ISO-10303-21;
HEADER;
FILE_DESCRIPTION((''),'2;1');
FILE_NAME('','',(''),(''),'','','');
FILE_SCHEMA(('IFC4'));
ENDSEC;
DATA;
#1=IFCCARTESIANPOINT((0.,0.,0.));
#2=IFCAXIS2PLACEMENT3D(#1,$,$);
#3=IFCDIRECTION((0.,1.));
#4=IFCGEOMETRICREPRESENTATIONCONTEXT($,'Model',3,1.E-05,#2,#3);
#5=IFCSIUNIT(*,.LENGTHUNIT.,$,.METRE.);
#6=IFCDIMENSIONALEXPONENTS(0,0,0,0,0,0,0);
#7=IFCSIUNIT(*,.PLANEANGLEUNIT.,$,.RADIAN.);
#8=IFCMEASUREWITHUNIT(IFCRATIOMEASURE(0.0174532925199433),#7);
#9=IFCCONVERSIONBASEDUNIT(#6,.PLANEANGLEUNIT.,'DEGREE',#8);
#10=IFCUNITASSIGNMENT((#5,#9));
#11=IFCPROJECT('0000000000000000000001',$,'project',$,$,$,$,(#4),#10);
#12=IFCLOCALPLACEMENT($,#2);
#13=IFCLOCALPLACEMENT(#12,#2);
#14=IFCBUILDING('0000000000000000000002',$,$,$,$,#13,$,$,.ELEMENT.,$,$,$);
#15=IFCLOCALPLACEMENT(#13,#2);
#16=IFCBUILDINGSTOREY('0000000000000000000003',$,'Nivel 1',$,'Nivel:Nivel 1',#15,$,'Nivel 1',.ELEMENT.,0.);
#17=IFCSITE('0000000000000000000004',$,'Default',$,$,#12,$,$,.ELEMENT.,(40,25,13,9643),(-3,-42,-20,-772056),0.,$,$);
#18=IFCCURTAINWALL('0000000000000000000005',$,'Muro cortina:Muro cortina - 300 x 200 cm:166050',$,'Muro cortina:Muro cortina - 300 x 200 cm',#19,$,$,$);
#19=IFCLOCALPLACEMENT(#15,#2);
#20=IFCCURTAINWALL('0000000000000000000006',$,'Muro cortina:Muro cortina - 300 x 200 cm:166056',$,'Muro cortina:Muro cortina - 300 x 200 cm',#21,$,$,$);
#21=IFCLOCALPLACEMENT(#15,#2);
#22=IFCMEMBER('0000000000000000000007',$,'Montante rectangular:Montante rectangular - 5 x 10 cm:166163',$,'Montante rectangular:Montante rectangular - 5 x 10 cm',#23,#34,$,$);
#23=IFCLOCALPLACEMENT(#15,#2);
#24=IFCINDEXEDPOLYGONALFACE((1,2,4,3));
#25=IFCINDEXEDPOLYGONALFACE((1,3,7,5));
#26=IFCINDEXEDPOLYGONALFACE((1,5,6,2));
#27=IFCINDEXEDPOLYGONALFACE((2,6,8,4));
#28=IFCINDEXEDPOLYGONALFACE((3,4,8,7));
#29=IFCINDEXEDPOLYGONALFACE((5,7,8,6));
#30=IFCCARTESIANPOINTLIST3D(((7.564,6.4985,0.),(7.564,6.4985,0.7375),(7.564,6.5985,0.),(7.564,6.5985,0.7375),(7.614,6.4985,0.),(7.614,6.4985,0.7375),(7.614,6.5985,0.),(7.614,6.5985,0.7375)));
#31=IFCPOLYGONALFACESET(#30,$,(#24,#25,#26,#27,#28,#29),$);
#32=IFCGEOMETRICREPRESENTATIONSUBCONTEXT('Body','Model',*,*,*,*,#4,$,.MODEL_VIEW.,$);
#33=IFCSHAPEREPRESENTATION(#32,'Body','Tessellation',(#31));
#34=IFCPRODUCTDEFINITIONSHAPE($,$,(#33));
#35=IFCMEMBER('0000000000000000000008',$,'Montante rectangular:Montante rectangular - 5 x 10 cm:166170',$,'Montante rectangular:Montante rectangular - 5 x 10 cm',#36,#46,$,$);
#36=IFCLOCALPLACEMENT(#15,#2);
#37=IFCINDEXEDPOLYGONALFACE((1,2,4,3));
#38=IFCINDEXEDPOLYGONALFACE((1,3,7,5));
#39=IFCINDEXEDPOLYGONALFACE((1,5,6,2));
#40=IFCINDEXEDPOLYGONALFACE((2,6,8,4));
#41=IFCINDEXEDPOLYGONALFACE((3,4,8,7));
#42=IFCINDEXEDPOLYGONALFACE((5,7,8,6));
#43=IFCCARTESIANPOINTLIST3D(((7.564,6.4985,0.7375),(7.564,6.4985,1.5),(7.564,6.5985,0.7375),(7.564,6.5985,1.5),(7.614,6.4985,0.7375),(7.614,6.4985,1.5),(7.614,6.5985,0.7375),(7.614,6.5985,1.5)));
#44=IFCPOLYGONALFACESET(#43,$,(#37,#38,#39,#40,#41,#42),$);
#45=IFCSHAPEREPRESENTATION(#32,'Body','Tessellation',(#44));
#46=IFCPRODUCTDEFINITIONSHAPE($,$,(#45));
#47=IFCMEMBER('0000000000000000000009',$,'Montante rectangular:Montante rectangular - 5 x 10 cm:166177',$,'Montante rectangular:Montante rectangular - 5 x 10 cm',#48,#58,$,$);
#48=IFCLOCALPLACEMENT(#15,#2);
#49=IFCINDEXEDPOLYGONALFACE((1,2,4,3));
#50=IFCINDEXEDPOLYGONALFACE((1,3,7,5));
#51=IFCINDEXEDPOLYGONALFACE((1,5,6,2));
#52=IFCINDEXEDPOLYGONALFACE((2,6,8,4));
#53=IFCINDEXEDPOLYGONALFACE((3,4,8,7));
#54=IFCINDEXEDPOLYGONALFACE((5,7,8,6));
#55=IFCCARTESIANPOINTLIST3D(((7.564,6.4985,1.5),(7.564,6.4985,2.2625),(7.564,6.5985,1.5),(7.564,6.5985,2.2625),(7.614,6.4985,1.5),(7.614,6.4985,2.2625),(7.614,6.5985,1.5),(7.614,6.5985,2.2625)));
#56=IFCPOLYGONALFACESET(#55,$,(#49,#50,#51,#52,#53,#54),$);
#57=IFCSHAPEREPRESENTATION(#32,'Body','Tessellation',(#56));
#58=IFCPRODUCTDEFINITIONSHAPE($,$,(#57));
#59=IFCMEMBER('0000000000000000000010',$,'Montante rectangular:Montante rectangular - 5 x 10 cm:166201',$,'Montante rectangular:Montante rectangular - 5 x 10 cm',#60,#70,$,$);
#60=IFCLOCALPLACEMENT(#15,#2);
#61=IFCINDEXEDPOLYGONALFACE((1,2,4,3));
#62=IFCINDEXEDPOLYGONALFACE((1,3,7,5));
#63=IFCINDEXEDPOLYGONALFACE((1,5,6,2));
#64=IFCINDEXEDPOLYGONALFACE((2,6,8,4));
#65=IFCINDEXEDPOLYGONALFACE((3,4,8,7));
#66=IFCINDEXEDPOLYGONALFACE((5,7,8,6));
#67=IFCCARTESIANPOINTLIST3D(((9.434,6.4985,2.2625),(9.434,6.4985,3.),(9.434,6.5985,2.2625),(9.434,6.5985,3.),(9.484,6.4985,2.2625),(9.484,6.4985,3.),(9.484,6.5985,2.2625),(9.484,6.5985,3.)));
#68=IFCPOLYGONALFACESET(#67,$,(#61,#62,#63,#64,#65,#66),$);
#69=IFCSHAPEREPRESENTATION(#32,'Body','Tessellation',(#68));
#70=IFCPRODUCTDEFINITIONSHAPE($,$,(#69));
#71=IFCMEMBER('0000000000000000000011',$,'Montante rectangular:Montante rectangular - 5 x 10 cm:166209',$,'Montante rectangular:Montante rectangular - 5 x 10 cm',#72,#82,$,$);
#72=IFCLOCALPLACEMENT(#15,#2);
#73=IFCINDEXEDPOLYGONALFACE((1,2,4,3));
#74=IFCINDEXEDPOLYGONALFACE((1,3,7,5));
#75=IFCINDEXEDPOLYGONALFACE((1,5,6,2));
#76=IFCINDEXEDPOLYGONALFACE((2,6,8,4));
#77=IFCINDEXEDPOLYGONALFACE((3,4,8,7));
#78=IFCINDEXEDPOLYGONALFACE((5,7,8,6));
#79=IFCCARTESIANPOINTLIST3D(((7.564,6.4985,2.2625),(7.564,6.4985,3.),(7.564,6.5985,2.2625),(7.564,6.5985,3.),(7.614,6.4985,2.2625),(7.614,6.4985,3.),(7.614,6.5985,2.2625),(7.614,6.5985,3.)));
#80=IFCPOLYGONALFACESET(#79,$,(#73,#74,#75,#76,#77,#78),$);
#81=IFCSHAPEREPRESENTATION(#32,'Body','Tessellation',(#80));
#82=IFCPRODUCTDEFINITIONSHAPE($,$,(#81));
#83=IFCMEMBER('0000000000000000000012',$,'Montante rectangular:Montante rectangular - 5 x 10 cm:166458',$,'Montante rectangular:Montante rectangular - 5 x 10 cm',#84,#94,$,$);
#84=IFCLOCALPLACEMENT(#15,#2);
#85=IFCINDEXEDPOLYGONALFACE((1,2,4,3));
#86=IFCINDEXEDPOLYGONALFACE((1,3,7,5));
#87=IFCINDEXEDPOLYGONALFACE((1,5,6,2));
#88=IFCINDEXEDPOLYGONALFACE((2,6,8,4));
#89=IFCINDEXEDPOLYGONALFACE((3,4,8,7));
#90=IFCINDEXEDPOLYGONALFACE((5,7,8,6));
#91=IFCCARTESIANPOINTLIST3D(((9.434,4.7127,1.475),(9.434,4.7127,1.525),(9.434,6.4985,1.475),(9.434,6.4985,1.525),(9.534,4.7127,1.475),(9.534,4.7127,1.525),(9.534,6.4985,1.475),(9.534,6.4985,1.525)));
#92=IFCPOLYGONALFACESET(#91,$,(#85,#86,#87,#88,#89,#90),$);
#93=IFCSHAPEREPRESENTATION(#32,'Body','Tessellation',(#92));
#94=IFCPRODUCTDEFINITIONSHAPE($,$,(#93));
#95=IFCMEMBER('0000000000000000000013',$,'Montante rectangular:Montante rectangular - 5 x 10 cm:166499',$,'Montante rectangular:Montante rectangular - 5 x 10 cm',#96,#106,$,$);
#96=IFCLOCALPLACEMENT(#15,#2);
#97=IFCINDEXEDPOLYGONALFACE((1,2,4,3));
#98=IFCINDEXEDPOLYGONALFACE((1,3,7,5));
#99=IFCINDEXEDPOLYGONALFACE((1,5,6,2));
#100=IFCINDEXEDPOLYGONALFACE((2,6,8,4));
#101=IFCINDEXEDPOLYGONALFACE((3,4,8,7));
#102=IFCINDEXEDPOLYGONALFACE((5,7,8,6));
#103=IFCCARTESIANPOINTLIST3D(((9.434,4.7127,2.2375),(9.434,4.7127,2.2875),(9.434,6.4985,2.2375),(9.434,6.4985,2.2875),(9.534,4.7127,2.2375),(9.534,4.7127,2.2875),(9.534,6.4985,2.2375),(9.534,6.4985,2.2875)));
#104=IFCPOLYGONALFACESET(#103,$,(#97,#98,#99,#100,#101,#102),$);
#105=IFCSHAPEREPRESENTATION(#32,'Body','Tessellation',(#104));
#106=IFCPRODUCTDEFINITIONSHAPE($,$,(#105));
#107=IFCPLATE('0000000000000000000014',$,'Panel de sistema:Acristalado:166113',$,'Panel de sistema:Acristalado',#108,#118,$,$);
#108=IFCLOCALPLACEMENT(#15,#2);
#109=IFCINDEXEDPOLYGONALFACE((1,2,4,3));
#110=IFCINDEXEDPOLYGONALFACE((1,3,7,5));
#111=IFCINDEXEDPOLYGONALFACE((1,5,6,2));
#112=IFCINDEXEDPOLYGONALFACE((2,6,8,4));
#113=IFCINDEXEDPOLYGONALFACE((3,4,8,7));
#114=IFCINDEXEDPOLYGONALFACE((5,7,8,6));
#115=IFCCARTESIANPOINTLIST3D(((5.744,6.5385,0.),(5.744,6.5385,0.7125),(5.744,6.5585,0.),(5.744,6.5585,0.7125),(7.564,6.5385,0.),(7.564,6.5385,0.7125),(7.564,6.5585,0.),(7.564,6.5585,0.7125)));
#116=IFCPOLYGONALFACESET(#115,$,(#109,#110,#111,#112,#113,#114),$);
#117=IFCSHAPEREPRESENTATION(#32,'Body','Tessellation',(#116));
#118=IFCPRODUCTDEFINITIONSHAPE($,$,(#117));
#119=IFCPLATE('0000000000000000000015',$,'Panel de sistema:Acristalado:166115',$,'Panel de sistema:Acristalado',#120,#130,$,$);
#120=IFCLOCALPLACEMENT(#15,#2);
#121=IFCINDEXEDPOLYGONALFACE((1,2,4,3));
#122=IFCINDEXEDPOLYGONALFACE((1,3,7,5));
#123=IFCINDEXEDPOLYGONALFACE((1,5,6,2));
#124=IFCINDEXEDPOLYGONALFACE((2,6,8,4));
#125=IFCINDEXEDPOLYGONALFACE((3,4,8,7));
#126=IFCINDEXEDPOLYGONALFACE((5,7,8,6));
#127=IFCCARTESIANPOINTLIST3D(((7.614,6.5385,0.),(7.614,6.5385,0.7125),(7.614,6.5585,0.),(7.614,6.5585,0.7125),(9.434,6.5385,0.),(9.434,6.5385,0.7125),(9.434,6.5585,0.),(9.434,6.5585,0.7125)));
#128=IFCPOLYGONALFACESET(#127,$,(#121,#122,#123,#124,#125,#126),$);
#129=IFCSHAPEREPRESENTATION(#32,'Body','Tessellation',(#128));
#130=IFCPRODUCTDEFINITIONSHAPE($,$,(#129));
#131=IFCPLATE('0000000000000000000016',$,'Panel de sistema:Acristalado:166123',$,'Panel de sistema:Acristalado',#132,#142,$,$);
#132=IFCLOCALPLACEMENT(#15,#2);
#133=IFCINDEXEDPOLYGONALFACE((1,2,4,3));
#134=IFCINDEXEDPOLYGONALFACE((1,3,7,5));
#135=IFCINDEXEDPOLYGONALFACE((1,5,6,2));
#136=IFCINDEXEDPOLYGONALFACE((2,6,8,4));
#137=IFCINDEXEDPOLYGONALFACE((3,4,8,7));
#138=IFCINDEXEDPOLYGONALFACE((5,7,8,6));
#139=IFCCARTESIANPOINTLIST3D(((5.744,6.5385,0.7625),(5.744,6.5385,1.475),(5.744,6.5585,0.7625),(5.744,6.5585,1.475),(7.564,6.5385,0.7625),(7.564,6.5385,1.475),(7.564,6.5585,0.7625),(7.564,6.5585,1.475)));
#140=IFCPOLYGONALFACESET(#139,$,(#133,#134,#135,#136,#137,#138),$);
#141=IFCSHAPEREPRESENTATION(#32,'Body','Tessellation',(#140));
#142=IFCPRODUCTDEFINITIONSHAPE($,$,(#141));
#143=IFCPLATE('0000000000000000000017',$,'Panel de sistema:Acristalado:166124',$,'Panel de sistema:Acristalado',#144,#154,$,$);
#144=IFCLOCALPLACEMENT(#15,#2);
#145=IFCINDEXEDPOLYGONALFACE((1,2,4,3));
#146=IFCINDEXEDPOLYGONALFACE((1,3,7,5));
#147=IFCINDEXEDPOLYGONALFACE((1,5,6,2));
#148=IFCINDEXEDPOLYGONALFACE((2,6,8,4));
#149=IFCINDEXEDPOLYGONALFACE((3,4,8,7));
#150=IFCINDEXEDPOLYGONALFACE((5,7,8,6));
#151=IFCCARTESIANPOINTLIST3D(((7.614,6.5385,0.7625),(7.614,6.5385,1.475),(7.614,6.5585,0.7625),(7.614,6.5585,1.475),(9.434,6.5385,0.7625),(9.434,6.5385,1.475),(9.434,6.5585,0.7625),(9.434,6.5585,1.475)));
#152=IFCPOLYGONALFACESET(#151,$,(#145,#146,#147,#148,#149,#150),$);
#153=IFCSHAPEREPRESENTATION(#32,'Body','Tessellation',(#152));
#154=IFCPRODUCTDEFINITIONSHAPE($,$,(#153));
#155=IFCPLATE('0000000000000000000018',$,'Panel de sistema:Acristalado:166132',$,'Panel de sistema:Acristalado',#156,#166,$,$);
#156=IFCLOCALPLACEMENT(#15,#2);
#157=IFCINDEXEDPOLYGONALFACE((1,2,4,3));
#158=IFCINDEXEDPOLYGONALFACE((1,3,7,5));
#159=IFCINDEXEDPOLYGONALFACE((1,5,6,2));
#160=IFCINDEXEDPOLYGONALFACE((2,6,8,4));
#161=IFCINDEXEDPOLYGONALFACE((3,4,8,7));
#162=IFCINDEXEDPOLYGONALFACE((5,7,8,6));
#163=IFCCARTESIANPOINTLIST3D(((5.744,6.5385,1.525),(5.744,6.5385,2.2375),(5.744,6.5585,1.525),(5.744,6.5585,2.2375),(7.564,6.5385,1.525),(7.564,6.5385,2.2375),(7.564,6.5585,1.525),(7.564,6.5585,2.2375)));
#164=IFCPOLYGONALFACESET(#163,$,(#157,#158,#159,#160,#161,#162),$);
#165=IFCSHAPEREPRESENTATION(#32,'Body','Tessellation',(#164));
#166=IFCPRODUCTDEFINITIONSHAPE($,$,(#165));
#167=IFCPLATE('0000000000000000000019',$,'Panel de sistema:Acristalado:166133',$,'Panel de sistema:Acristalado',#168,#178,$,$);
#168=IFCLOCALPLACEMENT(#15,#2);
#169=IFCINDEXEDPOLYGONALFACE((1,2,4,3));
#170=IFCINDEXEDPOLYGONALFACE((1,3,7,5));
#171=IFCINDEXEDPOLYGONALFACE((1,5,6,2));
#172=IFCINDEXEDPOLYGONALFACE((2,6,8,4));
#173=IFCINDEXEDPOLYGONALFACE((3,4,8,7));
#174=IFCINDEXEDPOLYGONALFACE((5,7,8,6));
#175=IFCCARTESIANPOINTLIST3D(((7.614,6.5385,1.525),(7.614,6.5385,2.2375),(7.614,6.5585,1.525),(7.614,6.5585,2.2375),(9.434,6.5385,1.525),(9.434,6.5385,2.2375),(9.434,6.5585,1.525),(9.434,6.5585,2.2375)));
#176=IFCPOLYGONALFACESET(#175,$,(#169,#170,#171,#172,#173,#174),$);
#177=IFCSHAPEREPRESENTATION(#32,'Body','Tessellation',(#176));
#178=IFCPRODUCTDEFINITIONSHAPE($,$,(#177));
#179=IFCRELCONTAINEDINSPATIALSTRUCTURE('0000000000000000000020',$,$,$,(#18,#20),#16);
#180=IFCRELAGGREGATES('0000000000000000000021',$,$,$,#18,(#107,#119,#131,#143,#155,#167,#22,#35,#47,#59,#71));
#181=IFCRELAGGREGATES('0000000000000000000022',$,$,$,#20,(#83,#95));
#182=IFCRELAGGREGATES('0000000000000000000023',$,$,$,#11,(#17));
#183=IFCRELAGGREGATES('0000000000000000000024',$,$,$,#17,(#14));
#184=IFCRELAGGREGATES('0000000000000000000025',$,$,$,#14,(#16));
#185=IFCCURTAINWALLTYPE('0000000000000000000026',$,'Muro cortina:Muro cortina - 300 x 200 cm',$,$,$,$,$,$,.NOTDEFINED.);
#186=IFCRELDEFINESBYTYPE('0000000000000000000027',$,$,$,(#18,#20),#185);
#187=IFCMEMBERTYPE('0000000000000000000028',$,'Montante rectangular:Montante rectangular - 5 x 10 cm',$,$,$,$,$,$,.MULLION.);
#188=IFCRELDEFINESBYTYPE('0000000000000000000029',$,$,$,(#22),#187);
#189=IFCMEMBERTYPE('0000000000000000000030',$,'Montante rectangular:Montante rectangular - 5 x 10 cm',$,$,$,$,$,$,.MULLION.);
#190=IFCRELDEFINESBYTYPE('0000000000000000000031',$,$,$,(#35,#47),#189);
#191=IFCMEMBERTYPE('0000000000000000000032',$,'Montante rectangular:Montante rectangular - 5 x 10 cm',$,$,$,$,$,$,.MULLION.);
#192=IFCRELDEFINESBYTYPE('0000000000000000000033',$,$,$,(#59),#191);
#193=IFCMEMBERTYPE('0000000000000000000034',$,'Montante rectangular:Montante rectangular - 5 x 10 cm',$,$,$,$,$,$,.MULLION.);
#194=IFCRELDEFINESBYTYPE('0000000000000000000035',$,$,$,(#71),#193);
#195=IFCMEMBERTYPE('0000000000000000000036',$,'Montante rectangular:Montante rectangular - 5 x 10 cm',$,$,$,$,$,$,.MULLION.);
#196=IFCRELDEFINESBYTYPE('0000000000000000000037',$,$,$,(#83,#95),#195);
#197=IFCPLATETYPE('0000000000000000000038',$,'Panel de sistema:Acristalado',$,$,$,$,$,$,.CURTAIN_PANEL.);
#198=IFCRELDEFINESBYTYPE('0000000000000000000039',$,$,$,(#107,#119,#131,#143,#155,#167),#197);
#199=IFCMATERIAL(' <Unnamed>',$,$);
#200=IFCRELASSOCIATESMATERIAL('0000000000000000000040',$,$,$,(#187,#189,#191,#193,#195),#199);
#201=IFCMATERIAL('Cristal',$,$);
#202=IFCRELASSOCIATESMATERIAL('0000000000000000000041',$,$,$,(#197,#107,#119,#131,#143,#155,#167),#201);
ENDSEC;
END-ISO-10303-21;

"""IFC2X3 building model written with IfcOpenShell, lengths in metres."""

from ifc_helpers import new_model, entity, si_unit, converted_unit, direction, frame, origin, origin_2d_with_axis, place, context, subcontext, project, spatial, rectangle, extrude, source, transform, mapped, material, type_object, type_shapes, element, aggregate, save


model = new_model("IFC2X3")

# Units and contexts
model_context = context("Model", 3, precision=1e-05, world=origin(), true_north=direction((0.0, 1.0)))
body_context = subcontext(model_context, "Body", "Model", "MODEL_VIEW")
ifc_project = project(units=[si_unit("LENGTHUNIT", "METRE"), converted_unit("PLANEANGLEUNIT", "DEGREE", entity("IfcRatioMeasure", 0.0174532925199433), si_unit("PLANEANGLEUNIT", "RADIAN"), dimensions=[0, 0, 0, 0, 0, 0, 0])], contexts=[model_context])

# Site, building, storey
site_placement = place(None, origin())
site = spatial("IfcSite", under=ifc_project, at=site_placement, Name="Default", CompositionType="ELEMENT", RefLatitude=(40, 25, 13, 9643), RefLongitude=(-3, -42, -20, -772056), RefElevation=0.0)
building_placement = place(site_placement, origin())
building = spatial("IfcBuilding", under=site, at=building_placement, CompositionType="ELEMENT")
storey_placement = place(building_placement, origin())
storey = spatial("IfcBuildingStorey", under=building, at=storey_placement, Name="Nivel 1", ObjectType="Nivel:Nivel 1", LongName="Nivel 1", CompositionType="ELEMENT", Elevation=0.0)

# Curtain walls
curtain_wall_type = type_object("IfcCurtainWallType", Name="Muro cortina:Muro cortina - 300 x 200 cm", PredefinedType="NOTDEFINED")
curtain_wall_1_placement = place(storey_placement, origin())
curtain_wall_1 = element("IfcCurtainWall", 1, at=curtain_wall_1_placement, inside=storey, type_object=curtain_wall_type, Name="Muro cortina:Muro cortina - 300 x 200 cm:166050", ObjectType="Muro cortina:Muro cortina - 300 x 200 cm")
ifc_material_1 = material(Name=" <Unnamed>")
curtain_wall_2_placement = place(storey_placement, origin())
curtain_wall_2 = element("IfcCurtainWall", 2, at=curtain_wall_2_placement, inside=storey, type_object=curtain_wall_type, Name="Muro cortina:Muro cortina - 300 x 200 cm:166056", ObjectType="Muro cortina:Muro cortina - 300 x 200 cm")

# Members
member_type_1 = type_object("IfcMemberType", Name="Montante rectangular:Montante rectangular - 5 x 10 cm", PredefinedType="MULLION", material=ifc_material_1)
shared_shape_1 = source(origin(), body_context, "Body", "SweptSolid", [
    extrude(rectangle(XDim=0.1, YDim=0.05, at=origin_2d_with_axis()), frame((0.0, 0.0, -0.7375), z_axis=(0.0, 0.0, 1.0), x_axis=(0.0, -1.0, 0.0)), (0.0, 0.0, 1.0), 0.7375),
])
type_shapes(member_type_1, [shared_shape_1])
member_1_placement = place(storey_placement, frame((7.589, 6.5485, 0.0), z_axis=(0.0, 0.0, -1.0), x_axis=(1.0, 0.0, 0.0)))
member_1 = element("IfcMember", 3, at=member_1_placement, type_object=member_type_1, Name="Montante rectangular:Montante rectangular - 5 x 10 cm:166163", ObjectType="Montante rectangular:Montante rectangular - 5 x 10 cm", context=body_context, shape_type="MappedRepresentation", body=[
    mapped(shared_shape_1, transform((0.0, 0.0, 0.0), scale=1.0)),
])
member_type_2 = type_object("IfcMemberType", Name="Montante rectangular:Montante rectangular - 5 x 10 cm", PredefinedType="MULLION", material=ifc_material_1)
shared_shape_2 = source(origin(), body_context, "Body", "SweptSolid", [
    extrude(rectangle(XDim=0.1, YDim=0.05, at=origin_2d_with_axis()), frame((0.0, 0.0, -0.7625), z_axis=(0.0, 0.0, 1.0), x_axis=(0.0, -1.0, 0.0)), (0.0, 0.0, 1.0), 0.7625),
])
type_shapes(member_type_2, [shared_shape_2])
member_2_placement = place(storey_placement, frame((7.589, 6.5485, 0.7375), z_axis=(0.0, 0.0, -1.0), x_axis=(1.0, 0.0, 0.0)))
member_2 = element("IfcMember", 4, at=member_2_placement, type_object=member_type_2, Name="Montante rectangular:Montante rectangular - 5 x 10 cm:166170", ObjectType="Montante rectangular:Montante rectangular - 5 x 10 cm", context=body_context, shape_type="MappedRepresentation", body=[
    mapped(shared_shape_2, transform((0.0, 0.0, 0.0), scale=1.0)),
])
member_3_placement = place(storey_placement, frame((7.589, 6.5485, 1.5), z_axis=(0.0, 0.0, -1.0), x_axis=(1.0, 0.0, 0.0)))
member_3 = element("IfcMember", 5, at=member_3_placement, type_object=member_type_2, Name="Montante rectangular:Montante rectangular - 5 x 10 cm:166177", ObjectType="Montante rectangular:Montante rectangular - 5 x 10 cm", context=body_context, shape_type="MappedRepresentation", body=[
    mapped(shared_shape_2, transform((0.0, 0.0, 0.0), scale=1.0)),
])
member_type_3 = type_object("IfcMemberType", Name="Montante rectangular:Montante rectangular - 5 x 10 cm", PredefinedType="MULLION", material=ifc_material_1)
shared_shape_3 = source(origin(), body_context, "Body", "SweptSolid", [
    extrude(rectangle(XDim=0.1, YDim=0.05, at=origin_2d_with_axis()), frame((-0.025, 0.0, -0.7375), z_axis=(0.0, 0.0, 1.0), x_axis=(0.0, -1.0, 0.0)), (0.0, 0.0, 1.0), 0.7375),
])
type_shapes(member_type_3, [shared_shape_3])
member_4_placement = place(storey_placement, frame((9.484, 6.5485, 2.2625), z_axis=(0.0, 0.0, -1.0), x_axis=(1.0, 0.0, 0.0)))
member_4 = element("IfcMember", 6, at=member_4_placement, type_object=member_type_3, Name="Montante rectangular:Montante rectangular - 5 x 10 cm:166201", ObjectType="Montante rectangular:Montante rectangular - 5 x 10 cm", context=body_context, shape_type="MappedRepresentation", body=[
    mapped(shared_shape_3, transform((0.0, 0.0, 0.0), scale=1.0)),
])
member_type_4 = type_object("IfcMemberType", Name="Montante rectangular:Montante rectangular - 5 x 10 cm", PredefinedType="MULLION", material=ifc_material_1)
shared_shape_4 = source(origin(), body_context, "Body", "SweptSolid", [
    extrude(rectangle(XDim=0.1, YDim=0.05, at=origin_2d_with_axis()), frame((0.0, 0.0, -0.7375), z_axis=(0.0, 0.0, 1.0), x_axis=(0.0, -1.0, 0.0)), (0.0, 0.0, 1.0), 0.7375),
])
type_shapes(member_type_4, [shared_shape_4])
member_5_placement = place(storey_placement, frame((7.589, 6.5485, 2.2625), z_axis=(0.0, 0.0, -1.0), x_axis=(1.0, 0.0, 0.0)))
member_5 = element("IfcMember", 7, at=member_5_placement, type_object=member_type_4, Name="Montante rectangular:Montante rectangular - 5 x 10 cm:166209", ObjectType="Montante rectangular:Montante rectangular - 5 x 10 cm", context=body_context, shape_type="MappedRepresentation", body=[
    mapped(shared_shape_4, transform((0.0, 0.0, 0.0), scale=1.0)),
])
member_type_5 = type_object("IfcMemberType", Name="Montante rectangular:Montante rectangular - 5 x 10 cm", PredefinedType="MULLION", material=ifc_material_1)
shared_shape_5 = source(origin(), body_context, "Body", "SweptSolid", [
    extrude(rectangle(XDim=0.1, YDim=0.05, at=origin_2d_with_axis()), frame((0.0, 0.0, -1.7857), z_axis=(0.0, 0.0, 1.0), x_axis=(0.0, -1.0, 0.0)), (0.0, 0.0, 1.0), 1.7857),
])
type_shapes(member_type_5, [shared_shape_5])
member_6_placement = place(storey_placement, frame((9.484, 4.7127, 1.5), z_axis=(0.0, -1.0, 0.0), x_axis=(0.0, 0.0, 1.0)))
member_6 = element("IfcMember", 8, at=member_6_placement, type_object=member_type_5, Name="Montante rectangular:Montante rectangular - 5 x 10 cm:166458", ObjectType="Montante rectangular:Montante rectangular - 5 x 10 cm", context=body_context, shape_type="MappedRepresentation", body=[
    mapped(shared_shape_5, transform((0.0, 0.0, 0.0), scale=1.0)),
])
member_7_placement = place(storey_placement, frame((9.484, 4.7127, 2.2625), z_axis=(0.0, -1.0, 0.0), x_axis=(0.0, 0.0, 1.0)))
member_7 = element("IfcMember", 9, at=member_7_placement, type_object=member_type_5, Name="Montante rectangular:Montante rectangular - 5 x 10 cm:166499", ObjectType="Montante rectangular:Montante rectangular - 5 x 10 cm", context=body_context, shape_type="MappedRepresentation", body=[
    mapped(shared_shape_5, transform((0.0, 0.0, 0.0), scale=1.0)),
])

# Plates
ifc_material_2 = material(Name="Cristal")
plate_type_1 = type_object("IfcPlateType", Name="Panel de sistema:Acristalado", PredefinedType="CURTAIN_PANEL", material=ifc_material_2)
shared_shape_6 = source(origin(), body_context, "Body", "SweptSolid", [
    extrude(rectangle(XDim=0.02, YDim=1.82, at=origin_2d_with_axis()), frame((0.0, 0.0, 0.0), z_axis=(0.0, 0.0, 1.0), x_axis=(0.0, 1.0, 0.0)), (0.0, 0.0, 1.0), 0.7125),
])
type_shapes(plate_type_1, [shared_shape_6])
plate_1_placement = place(curtain_wall_1_placement, frame((6.654, 6.5485, 0.0)))
plate_1 = element("IfcPlate", 10, at=plate_1_placement, type_object=plate_type_1, material=ifc_material_2, Name="Panel de sistema:Acristalado:166113", ObjectType="Panel de sistema:Acristalado", context=body_context, shape_type="MappedRepresentation", body=[
    mapped(shared_shape_6, transform((0.0, 0.0, 0.0), scale=1.0)),
])
plate_2_placement = place(curtain_wall_1_placement, frame((8.524, 6.5485, 0.0)))
plate_2 = element("IfcPlate", 11, at=plate_2_placement, type_object=plate_type_1, material=ifc_material_2, Name="Panel de sistema:Acristalado:166115", ObjectType="Panel de sistema:Acristalado", context=body_context, shape_type="MappedRepresentation", body=[
    mapped(shared_shape_6, transform((0.0, 0.0, 0.0), scale=1.0)),
])
plate_3_placement = place(curtain_wall_1_placement, frame((6.654, 6.5485, 0.7625)))
plate_3 = element("IfcPlate", 12, at=plate_3_placement, type_object=plate_type_1, material=ifc_material_2, Name="Panel de sistema:Acristalado:166123", ObjectType="Panel de sistema:Acristalado", context=body_context, shape_type="MappedRepresentation", body=[
    mapped(shared_shape_6, transform((0.0, 0.0, 0.0), scale=1.0)),
])
plate_4_placement = place(curtain_wall_1_placement, frame((8.524, 6.5485, 0.7625)))
plate_4 = element("IfcPlate", 13, at=plate_4_placement, type_object=plate_type_1, material=ifc_material_2, Name="Panel de sistema:Acristalado:166124", ObjectType="Panel de sistema:Acristalado", context=body_context, shape_type="MappedRepresentation", body=[
    mapped(shared_shape_6, transform((0.0, 0.0, 0.0), scale=1.0)),
])
plate_5_placement = place(curtain_wall_1_placement, frame((6.654, 6.5485, 1.525)))
plate_5 = element("IfcPlate", 14, at=plate_5_placement, type_object=plate_type_1, material=ifc_material_2, Name="Panel de sistema:Acristalado:166132", ObjectType="Panel de sistema:Acristalado", context=body_context, shape_type="MappedRepresentation", body=[
    mapped(shared_shape_6, transform((0.0, 0.0, 0.0), scale=1.0)),
])
plate_6_placement = place(curtain_wall_1_placement, frame((8.524, 6.5485, 1.525)))
plate_6 = element("IfcPlate", 15, at=plate_6_placement, type_object=plate_type_1, material=ifc_material_2, Name="Panel de sistema:Acristalado:166133", ObjectType="Panel de sistema:Acristalado", context=body_context, shape_type="MappedRepresentation", body=[
    mapped(shared_shape_6, transform((0.0, 0.0, 0.0), scale=1.0)),
])
aggregate(curtain_wall_1, [plate_1, plate_2, plate_3, plate_4, plate_5, plate_6, member_1, member_2, member_3, member_4, member_5])
aggregate(curtain_wall_2, [member_6, member_7])

save(model, "model.ifc")
